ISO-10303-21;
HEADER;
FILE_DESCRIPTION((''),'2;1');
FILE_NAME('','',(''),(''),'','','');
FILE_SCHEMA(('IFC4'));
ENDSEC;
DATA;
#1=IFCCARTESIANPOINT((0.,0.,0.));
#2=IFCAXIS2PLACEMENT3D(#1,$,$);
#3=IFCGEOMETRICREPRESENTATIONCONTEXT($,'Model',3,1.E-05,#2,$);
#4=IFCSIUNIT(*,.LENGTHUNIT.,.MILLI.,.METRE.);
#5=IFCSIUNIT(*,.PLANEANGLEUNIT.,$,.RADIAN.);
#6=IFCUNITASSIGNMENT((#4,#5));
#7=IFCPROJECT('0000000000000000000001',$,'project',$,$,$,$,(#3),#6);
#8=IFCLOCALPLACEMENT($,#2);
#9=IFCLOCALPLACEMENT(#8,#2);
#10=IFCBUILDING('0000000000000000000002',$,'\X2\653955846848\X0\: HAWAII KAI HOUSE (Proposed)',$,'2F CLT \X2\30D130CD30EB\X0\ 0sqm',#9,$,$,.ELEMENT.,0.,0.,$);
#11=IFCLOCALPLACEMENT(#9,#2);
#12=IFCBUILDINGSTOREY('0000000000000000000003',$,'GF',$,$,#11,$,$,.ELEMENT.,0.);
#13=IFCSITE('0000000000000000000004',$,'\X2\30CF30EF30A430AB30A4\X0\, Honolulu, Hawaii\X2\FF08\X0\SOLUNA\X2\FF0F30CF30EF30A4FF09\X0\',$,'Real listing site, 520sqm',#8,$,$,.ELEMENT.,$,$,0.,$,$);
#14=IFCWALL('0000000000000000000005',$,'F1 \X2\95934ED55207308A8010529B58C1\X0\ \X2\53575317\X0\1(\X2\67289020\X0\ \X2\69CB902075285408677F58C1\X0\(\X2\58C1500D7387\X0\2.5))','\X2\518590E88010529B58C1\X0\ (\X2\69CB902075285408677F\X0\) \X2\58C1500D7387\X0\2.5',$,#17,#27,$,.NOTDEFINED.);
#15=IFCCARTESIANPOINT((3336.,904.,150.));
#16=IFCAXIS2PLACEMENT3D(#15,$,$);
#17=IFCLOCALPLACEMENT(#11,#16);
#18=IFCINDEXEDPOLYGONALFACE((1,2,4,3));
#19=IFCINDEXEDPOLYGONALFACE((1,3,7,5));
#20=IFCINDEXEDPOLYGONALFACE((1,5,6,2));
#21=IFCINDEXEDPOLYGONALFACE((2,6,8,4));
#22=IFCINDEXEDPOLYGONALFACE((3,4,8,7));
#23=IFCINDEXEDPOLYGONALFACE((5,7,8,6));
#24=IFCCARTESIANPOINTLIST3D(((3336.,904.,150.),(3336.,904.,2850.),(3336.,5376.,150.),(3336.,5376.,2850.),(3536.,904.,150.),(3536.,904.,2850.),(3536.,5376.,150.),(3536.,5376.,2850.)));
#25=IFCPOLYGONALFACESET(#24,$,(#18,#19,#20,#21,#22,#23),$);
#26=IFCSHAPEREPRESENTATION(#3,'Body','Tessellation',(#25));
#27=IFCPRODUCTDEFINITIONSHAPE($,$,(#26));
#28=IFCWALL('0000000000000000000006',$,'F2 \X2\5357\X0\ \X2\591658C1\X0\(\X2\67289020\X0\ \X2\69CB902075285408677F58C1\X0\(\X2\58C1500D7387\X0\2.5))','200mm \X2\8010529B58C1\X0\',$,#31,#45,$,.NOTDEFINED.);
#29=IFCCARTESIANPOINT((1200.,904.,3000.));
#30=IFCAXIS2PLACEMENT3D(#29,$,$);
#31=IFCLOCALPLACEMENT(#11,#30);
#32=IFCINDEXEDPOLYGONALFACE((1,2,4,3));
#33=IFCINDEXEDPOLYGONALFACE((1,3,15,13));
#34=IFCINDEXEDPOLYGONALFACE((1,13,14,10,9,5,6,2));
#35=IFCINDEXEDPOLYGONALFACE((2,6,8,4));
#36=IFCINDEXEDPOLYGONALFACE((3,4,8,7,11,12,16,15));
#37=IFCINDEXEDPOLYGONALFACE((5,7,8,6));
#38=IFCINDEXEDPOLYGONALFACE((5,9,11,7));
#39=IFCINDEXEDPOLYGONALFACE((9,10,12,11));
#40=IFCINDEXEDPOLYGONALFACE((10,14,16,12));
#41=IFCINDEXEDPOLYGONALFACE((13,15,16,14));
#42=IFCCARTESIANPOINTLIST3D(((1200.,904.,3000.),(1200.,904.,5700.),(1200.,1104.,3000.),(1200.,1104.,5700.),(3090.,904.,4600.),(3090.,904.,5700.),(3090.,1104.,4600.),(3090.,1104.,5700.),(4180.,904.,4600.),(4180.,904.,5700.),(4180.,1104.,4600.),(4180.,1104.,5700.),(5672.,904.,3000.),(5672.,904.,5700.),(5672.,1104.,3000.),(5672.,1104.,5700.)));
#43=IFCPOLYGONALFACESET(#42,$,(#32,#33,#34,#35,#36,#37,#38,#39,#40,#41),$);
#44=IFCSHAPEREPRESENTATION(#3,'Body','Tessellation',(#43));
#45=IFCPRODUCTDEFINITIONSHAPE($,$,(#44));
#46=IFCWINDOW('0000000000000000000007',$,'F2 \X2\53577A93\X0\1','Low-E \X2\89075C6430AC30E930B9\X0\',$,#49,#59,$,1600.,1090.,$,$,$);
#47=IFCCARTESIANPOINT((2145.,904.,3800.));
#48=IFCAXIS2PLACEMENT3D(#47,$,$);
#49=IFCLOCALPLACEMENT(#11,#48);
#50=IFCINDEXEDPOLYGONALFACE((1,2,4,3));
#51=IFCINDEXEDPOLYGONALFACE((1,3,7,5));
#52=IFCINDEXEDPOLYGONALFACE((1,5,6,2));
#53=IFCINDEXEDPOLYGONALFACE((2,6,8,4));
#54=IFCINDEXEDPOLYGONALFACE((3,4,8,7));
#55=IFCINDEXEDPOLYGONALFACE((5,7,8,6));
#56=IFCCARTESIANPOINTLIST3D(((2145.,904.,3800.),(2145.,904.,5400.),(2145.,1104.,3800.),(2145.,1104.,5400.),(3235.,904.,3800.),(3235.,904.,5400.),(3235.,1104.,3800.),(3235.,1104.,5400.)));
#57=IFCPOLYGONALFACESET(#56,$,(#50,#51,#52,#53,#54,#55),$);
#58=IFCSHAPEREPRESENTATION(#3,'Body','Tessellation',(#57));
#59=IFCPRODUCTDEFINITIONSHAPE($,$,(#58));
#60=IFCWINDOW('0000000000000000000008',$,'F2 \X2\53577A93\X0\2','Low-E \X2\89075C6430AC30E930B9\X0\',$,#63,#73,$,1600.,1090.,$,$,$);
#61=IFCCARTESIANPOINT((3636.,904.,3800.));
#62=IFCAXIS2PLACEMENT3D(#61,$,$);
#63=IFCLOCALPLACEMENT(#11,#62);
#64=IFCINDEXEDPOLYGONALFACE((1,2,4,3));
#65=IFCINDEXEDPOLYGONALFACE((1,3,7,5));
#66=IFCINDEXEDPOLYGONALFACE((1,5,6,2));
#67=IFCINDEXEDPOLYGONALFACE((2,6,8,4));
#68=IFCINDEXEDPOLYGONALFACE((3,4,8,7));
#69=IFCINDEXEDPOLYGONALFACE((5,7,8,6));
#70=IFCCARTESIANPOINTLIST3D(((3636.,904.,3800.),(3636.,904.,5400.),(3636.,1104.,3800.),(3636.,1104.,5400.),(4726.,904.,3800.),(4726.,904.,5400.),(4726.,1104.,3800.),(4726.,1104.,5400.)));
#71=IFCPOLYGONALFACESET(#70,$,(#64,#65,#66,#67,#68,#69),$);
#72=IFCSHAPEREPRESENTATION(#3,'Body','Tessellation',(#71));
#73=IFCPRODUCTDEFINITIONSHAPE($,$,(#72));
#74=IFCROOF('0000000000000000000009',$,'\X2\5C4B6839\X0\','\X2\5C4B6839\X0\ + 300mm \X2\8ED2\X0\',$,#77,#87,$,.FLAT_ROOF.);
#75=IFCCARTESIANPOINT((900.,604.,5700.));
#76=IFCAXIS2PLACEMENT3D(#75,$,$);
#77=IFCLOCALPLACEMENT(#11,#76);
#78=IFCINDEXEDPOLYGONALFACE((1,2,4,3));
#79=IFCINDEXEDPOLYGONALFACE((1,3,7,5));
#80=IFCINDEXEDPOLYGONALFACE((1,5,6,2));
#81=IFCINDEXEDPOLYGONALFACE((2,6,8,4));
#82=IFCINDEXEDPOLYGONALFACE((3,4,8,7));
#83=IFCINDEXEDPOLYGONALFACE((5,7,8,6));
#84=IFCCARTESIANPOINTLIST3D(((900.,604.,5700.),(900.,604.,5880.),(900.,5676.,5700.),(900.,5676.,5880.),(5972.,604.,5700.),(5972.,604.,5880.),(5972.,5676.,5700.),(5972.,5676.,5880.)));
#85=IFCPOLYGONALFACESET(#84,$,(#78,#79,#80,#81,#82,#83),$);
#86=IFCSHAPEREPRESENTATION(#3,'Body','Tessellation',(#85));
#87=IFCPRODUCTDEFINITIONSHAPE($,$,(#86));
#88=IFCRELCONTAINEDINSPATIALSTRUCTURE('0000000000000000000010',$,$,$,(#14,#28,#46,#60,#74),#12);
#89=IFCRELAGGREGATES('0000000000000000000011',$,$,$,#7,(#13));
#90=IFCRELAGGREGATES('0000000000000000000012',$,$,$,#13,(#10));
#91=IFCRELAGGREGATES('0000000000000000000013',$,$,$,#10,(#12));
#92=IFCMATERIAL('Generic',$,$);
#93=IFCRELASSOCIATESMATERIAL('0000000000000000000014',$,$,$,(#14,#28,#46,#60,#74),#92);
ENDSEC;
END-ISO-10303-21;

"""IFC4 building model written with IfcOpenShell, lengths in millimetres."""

from ifc_helpers import new_model, si_unit, frame, frame_2d, origin, place, context, project, spatial, rectangle, extrude, material, element, fill, save


model = new_model("IFC4")

# Units and contexts
model_context = context("Model", 3, precision=1e-05, world=origin())
ifc_project = project(units=[si_unit("LENGTHUNIT", "METRE", prefix="MILLI"), si_unit("PLANEANGLEUNIT", "RADIAN")], contexts=[model_context])

# Site, building, storey
site_placement = place(None, origin())
site = spatial("IfcSite", under=ifc_project, at=site_placement, Name="ハワイカイ, Honolulu, Hawaii（SOLUNA／ハワイ）", ObjectType="Real listing site, 520sqm", CompositionType="ELEMENT", RefElevation=0.0)
building_placement = place(site_placement, origin())
building = spatial("IfcBuilding", under=site, at=building_placement, Name="改善案: HAWAII KAI HOUSE (Proposed)", ObjectType="2F CLT パネル 0sqm", CompositionType="ELEMENT", ElevationOfRefHeight=0.0, ElevationOfTerrain=0.0)
storey_placement = place(building_placement, origin())
storey = spatial("IfcBuildingStorey", under=building, at=storey_placement, Name="GF", CompositionType="ELEMENT", Elevation=0.0)

# Shared definitions
ifc_material_1 = material(Name="Generic")

# Wall
wall_1_placement = place(storey_placement, frame((3336.0, 904.0, 150.0)))
element("IfcWall", 1, at=wall_1_placement, inside=storey, material=ifc_material_1, Name="F1 間仕切り耐力壁 南北1(木造 構造用合板壁(壁倍率2.5))", Description="内部耐力壁 (構造用合板) 壁倍率2.5", PredefinedType="NOTDEFINED", context=model_context, shape_type="SweptSolid", body=[
    extrude(rectangle(XDim=200.0, YDim=4472.0, at=frame_2d((100.0, 2236.0))), frame((3336.0, 904.0, 150.0)), (0.0, 0.0, 1.0), 2700.0),
])

# Wall, openings, windows
wall_2_placement = place(storey_placement, frame((1200.0, 904.0, 3000.0)))
wall_2 = element("IfcWall", 2, at=wall_2_placement, inside=storey, material=ifc_material_1, Name="F2 南 外壁(木造 構造用合板壁(壁倍率2.5))", Description="200mm 耐力壁", PredefinedType="NOTDEFINED", context=model_context, shape_type="SweptSolid", body=[
    extrude(rectangle(XDim=4472.0, YDim=200.0, at=frame_2d((2236.0, 100.0))), frame((1200.0, 904.0, 3000.0)), (0.0, 0.0, 1.0), 2700.0),
])
opening_1_placement = place(storey_placement, frame((2145.0, 904.0, 3800.0)))
opening_1 = element("IfcOpeningElement", 3, at=opening_1_placement, cuts=wall_2, PredefinedType="NOTDEFINED", context=model_context, shape_type="SweptSolid", body=[
    extrude(rectangle(XDim=1090.0, YDim=200.0, at=frame_2d((545.0, 100.0))), frame((2145.0, 904.0, 3800.0)), (0.0, 0.0, 1.0), 1600.0),
])
opening_2_placement = place(storey_placement, frame((3636.0, 904.0, 3800.0)))
opening_2 = element("IfcOpeningElement", 4, at=opening_2_placement, cuts=wall_2, PredefinedType="NOTDEFINED", context=model_context, shape_type="SweptSolid", body=[
    extrude(rectangle(XDim=1090.0, YDim=200.0, at=frame_2d((545.0, 100.0))), frame((3636.0, 904.0, 3800.0)), (0.0, 0.0, 1.0), 1600.0),
])
window_1_placement = place(storey_placement, frame((2145.0, 904.0, 3800.0)))
window_1 = element("IfcWindow", 5, at=window_1_placement, inside=storey, material=ifc_material_1, Name="F2 南窓1", Description="Low-E 複層ガラス", OverallHeight=1600.0, OverallWidth=1090.0, context=model_context, shape_type="SweptSolid", body=[
    extrude(rectangle(XDim=1090.0, YDim=200.0, at=frame_2d((545.0, 100.0))), frame((2145.0, 904.0, 3800.0)), (0.0, 0.0, 1.0), 1600.0),
])
fill(opening_1, window_1)
window_2_placement = place(storey_placement, frame((3636.0, 904.0, 3800.0)))
window_2 = element("IfcWindow", 6, at=window_2_placement, inside=storey, material=ifc_material_1, Name="F2 南窓2", Description="Low-E 複層ガラス", OverallHeight=1600.0, OverallWidth=1090.0, context=model_context, shape_type="SweptSolid", body=[
    extrude(rectangle(XDim=1090.0, YDim=200.0, at=frame_2d((545.0, 100.0))), frame((3636.0, 904.0, 3800.0)), (0.0, 0.0, 1.0), 1600.0),
])
fill(opening_2, window_2)

# Roof
roof_placement = place(storey_placement, frame((900.0, 604.0, 5700.0)))
element("IfcRoof", 7, at=roof_placement, inside=storey, material=ifc_material_1, Name="屋根", Description="屋根 + 300mm 軒", PredefinedType="FLAT_ROOF", context=model_context, shape_type="SweptSolid", body=[
    extrude(rectangle(XDim=5072.0, YDim=5072.0, at=frame_2d((2536.0, 2536.0))), frame((900.0, 604.0, 5700.0)), (0.0, 0.0, 1.0), 180.0),
])

save(model, "model.ifc")
